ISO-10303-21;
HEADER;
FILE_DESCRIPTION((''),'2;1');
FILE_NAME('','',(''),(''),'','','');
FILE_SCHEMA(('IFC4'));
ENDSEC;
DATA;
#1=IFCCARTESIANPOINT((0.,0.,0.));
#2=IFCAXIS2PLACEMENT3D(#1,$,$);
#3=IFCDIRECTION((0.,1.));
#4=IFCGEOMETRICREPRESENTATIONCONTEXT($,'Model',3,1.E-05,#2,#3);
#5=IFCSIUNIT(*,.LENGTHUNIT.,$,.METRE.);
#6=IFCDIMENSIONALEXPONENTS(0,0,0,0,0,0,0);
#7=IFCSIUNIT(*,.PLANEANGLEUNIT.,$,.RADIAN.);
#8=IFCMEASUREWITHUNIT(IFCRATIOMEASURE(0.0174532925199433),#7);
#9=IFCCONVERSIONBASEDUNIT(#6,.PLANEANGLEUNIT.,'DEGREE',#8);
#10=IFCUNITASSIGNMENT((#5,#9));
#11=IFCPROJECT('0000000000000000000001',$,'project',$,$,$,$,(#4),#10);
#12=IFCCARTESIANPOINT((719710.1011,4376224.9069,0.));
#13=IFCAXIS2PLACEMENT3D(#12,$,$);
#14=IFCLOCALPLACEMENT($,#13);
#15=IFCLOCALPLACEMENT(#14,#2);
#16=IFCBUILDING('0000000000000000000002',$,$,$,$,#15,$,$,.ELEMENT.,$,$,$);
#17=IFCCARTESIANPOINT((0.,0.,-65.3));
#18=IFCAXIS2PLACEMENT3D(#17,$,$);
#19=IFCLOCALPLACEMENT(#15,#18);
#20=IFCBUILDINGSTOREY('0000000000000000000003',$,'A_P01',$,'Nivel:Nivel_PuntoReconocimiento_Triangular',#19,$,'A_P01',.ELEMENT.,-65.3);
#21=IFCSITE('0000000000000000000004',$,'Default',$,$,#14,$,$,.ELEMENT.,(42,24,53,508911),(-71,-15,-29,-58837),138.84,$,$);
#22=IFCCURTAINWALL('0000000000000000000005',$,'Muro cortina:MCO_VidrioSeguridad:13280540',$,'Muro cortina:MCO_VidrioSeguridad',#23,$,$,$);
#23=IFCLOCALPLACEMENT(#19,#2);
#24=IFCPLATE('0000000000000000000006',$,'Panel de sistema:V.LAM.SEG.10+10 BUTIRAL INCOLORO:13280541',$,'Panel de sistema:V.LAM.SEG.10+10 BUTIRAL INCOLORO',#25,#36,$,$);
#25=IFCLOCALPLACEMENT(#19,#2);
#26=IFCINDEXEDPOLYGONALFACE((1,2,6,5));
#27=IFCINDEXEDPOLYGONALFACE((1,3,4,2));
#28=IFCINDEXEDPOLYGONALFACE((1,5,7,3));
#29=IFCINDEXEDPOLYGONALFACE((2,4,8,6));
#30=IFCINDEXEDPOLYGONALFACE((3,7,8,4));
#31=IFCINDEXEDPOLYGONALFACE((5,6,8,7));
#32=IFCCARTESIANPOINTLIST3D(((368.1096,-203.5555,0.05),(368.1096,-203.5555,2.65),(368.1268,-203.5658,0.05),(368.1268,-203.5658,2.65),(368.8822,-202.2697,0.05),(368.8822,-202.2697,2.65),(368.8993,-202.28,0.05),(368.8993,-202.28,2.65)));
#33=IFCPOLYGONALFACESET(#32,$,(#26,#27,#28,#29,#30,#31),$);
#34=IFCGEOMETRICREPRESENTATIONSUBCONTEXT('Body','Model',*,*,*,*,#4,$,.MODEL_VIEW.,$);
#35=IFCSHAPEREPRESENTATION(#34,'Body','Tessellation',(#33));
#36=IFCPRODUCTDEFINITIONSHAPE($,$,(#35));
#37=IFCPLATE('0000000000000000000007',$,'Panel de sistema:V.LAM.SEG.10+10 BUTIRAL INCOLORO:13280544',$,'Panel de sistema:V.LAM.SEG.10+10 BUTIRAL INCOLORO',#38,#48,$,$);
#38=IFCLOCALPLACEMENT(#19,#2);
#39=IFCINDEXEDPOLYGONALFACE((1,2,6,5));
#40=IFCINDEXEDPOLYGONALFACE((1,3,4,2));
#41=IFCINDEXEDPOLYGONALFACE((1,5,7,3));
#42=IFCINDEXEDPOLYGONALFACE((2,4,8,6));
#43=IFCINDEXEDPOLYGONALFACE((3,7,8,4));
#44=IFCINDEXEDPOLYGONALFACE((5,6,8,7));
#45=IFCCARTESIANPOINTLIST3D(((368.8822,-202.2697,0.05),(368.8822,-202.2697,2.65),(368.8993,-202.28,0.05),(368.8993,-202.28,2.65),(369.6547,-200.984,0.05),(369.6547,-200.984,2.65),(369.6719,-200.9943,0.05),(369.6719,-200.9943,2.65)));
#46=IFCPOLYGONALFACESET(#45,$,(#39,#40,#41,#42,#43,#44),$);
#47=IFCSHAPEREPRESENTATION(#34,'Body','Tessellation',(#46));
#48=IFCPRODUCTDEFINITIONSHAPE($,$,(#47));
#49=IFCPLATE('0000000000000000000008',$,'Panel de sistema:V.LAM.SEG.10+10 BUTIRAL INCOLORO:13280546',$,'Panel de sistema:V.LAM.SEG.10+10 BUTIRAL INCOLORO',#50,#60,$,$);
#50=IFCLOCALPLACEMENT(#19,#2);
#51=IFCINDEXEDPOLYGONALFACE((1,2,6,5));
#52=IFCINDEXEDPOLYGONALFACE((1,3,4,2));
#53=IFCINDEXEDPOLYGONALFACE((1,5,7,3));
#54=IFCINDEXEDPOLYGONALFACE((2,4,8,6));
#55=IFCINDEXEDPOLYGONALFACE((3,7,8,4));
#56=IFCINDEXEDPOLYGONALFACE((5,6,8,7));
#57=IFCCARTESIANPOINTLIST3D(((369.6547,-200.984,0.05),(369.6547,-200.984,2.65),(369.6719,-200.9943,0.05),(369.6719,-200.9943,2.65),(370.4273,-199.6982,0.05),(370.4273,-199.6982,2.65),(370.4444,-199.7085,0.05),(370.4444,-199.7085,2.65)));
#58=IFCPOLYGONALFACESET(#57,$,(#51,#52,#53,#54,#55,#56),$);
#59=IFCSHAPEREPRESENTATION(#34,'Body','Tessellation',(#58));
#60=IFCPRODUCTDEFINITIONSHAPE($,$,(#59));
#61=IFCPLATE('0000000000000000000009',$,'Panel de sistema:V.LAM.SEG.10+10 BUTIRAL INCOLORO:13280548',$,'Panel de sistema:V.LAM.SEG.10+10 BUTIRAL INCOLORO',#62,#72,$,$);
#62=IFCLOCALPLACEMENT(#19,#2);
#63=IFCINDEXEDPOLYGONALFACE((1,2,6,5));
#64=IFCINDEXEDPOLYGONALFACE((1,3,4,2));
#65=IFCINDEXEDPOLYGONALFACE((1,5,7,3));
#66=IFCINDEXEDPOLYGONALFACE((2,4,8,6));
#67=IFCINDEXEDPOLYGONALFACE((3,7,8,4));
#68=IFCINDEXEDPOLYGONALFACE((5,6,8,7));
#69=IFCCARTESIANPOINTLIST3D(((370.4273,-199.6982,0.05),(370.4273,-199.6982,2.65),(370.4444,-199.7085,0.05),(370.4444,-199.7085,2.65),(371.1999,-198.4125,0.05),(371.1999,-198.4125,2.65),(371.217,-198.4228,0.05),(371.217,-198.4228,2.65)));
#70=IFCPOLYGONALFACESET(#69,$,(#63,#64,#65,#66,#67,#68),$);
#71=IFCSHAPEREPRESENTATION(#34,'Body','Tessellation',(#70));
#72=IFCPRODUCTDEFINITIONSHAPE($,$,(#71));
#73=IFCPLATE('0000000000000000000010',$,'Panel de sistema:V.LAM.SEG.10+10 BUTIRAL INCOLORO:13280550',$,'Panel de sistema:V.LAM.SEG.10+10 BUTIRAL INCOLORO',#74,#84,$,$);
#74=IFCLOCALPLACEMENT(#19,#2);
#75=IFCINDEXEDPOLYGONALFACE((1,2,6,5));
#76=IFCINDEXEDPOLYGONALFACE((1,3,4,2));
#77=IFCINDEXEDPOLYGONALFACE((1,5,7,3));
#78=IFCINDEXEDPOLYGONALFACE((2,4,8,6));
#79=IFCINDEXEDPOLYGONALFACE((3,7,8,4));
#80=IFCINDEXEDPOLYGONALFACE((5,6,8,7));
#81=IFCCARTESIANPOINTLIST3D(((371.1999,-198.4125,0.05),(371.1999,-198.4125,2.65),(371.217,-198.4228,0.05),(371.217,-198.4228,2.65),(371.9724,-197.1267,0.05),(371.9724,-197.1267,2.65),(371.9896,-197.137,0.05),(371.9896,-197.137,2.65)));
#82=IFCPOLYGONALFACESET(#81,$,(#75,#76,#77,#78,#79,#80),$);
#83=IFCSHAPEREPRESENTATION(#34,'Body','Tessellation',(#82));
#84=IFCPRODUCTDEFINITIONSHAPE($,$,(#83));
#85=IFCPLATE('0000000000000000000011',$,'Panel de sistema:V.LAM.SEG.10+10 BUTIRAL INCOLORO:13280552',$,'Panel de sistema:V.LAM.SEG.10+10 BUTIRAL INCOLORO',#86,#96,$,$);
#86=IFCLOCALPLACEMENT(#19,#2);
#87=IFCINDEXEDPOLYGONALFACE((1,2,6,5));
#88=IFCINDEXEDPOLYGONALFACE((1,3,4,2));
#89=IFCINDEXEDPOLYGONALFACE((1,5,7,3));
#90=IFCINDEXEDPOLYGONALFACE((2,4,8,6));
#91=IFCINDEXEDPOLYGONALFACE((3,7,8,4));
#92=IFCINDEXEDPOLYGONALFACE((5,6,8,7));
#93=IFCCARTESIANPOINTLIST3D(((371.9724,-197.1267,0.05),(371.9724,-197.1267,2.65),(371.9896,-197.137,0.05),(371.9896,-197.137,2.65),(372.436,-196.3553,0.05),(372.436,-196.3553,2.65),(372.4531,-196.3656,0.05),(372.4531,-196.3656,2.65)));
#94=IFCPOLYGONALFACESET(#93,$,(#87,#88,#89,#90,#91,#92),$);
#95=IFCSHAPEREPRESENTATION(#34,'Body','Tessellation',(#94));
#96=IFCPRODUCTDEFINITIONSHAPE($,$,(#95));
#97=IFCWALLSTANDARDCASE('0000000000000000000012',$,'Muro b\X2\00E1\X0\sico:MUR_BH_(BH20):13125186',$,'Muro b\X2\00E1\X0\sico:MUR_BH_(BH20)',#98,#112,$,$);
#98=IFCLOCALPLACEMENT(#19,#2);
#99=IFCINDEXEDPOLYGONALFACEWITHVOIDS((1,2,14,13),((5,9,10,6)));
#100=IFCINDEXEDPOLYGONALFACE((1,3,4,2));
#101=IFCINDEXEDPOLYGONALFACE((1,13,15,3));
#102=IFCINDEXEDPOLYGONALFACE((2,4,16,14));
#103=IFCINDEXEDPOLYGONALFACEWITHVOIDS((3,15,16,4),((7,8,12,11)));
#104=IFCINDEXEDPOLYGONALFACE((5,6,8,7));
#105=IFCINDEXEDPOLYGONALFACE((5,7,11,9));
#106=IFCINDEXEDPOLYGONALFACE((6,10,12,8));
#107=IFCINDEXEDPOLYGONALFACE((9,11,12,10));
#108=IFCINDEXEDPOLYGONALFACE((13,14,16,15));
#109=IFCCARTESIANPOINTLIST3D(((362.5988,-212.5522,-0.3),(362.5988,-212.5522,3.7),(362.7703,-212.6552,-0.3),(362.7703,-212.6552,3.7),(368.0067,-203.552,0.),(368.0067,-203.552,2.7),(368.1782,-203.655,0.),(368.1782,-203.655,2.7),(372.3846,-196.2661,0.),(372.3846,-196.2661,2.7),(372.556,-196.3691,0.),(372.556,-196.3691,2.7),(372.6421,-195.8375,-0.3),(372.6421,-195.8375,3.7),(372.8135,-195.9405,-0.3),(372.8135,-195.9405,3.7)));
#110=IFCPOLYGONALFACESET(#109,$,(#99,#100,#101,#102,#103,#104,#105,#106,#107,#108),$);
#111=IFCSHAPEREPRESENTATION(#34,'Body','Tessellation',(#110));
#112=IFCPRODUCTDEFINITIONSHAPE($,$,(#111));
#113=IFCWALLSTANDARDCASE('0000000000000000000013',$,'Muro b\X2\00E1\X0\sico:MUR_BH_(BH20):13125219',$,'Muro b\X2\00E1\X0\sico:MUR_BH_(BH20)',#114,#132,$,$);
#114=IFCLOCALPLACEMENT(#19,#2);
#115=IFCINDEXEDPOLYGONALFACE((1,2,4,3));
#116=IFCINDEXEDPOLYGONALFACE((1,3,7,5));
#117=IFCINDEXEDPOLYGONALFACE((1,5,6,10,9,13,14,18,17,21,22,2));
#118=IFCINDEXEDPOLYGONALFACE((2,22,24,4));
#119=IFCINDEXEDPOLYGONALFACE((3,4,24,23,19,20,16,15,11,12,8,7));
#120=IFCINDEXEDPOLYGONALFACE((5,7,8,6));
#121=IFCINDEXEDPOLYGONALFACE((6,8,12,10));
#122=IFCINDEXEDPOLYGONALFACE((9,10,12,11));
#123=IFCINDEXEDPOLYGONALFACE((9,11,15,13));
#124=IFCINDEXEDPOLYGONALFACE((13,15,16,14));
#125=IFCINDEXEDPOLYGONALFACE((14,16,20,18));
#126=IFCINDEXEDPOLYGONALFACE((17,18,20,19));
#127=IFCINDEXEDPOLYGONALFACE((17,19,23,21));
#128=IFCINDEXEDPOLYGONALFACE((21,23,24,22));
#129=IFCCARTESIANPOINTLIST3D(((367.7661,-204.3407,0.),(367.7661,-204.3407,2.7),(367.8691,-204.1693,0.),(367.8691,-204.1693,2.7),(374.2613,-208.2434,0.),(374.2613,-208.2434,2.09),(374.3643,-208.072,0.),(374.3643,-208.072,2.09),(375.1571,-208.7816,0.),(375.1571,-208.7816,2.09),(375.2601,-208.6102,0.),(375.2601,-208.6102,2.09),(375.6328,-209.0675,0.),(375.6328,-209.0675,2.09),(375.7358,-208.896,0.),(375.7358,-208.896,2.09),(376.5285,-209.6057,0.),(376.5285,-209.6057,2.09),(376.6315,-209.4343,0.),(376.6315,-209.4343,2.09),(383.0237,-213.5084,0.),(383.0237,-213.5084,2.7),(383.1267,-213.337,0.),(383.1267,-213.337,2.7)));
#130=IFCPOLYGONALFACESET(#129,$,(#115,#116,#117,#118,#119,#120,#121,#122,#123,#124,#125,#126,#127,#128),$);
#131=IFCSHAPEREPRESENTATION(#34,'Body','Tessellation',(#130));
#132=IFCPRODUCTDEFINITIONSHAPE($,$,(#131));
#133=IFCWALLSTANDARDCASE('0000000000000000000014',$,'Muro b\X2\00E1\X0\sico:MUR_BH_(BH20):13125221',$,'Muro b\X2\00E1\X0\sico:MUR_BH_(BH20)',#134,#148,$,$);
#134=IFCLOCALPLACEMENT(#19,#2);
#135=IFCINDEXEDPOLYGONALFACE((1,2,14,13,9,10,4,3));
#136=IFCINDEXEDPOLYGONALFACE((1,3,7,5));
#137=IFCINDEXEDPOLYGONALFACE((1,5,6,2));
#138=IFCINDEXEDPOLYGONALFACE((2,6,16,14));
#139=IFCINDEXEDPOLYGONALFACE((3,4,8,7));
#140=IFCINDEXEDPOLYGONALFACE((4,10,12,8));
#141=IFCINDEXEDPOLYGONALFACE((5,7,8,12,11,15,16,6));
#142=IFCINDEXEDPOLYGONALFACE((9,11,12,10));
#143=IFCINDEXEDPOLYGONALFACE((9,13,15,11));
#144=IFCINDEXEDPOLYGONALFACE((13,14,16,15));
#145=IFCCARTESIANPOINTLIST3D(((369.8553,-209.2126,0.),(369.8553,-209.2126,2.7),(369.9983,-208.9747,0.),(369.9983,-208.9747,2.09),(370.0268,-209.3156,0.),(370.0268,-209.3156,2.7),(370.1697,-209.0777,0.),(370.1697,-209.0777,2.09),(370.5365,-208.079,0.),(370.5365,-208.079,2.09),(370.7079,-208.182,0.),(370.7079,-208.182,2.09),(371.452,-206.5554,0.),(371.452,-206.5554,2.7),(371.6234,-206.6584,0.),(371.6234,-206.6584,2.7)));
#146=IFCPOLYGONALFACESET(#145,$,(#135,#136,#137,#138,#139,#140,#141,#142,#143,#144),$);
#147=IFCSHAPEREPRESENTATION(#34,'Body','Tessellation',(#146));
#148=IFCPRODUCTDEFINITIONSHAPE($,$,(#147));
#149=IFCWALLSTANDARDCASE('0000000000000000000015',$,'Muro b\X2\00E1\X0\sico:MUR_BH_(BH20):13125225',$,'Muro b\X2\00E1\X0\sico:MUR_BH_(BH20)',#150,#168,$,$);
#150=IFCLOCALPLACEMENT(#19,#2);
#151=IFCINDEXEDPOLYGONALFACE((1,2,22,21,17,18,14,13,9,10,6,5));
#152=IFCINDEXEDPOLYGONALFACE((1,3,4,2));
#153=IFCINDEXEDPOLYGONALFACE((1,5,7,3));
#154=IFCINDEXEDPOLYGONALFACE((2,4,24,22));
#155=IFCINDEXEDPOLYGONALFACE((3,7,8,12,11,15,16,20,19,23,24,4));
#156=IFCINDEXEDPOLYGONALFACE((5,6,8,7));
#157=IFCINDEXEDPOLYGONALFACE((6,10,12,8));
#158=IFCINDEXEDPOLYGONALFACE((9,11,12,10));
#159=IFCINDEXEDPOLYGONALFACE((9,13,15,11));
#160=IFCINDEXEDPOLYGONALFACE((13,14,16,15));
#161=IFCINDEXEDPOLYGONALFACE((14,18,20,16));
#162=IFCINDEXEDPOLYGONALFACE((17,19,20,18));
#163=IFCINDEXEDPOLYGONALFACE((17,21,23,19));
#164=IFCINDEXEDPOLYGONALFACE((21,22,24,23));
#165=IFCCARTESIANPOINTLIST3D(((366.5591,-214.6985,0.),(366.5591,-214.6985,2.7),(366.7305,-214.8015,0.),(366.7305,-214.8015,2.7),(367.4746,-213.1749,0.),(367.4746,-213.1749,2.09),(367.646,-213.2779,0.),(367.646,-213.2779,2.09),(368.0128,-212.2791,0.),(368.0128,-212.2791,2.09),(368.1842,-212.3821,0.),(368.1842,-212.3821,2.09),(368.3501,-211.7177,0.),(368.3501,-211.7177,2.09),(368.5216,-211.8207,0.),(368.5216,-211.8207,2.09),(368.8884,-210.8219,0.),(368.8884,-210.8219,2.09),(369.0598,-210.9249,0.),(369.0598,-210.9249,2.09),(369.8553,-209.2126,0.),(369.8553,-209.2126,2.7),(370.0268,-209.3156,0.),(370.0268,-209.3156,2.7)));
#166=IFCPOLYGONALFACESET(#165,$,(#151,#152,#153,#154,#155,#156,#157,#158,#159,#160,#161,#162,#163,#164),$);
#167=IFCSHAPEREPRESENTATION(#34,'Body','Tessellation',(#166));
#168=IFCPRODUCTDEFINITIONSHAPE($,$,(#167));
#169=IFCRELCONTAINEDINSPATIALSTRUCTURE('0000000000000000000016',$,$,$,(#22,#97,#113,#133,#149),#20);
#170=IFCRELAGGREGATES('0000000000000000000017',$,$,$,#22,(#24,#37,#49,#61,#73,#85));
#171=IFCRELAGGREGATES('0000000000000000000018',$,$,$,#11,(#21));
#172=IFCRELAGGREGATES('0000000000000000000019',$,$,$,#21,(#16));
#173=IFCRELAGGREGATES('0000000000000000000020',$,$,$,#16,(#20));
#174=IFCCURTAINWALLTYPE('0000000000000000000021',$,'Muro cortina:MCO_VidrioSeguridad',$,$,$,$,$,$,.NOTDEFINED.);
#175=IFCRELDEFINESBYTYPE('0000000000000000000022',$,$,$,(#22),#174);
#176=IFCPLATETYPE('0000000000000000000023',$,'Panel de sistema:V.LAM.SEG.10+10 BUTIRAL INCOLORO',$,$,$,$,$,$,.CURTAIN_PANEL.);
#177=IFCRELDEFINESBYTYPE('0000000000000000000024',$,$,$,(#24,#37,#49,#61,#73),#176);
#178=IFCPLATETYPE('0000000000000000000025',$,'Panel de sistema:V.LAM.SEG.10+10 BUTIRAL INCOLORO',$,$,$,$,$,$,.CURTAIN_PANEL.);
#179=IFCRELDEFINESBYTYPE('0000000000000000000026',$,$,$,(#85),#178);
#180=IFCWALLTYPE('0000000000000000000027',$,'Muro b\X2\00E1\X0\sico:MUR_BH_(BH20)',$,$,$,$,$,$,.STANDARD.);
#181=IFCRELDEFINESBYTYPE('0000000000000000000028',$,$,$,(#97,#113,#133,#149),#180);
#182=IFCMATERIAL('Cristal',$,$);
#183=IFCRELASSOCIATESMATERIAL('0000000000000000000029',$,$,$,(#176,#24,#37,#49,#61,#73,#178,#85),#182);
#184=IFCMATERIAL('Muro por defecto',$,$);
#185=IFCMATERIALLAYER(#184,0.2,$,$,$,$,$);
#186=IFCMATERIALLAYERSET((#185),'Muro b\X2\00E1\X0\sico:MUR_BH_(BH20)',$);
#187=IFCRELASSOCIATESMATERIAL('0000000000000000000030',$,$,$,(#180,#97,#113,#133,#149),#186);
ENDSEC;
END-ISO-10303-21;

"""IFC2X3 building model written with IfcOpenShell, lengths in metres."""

from ifc_helpers import new_model, entity, si_unit, converted_unit, direction, frame, frame_2d, origin, origin_2d_with_axis, place, context, subcontext, project, spatial, rectangle, extrude, source, transform, mapped, material, layer, layer_set, layer_usage, type_object, type_shapes, element, aggregate, save


model = new_model("IFC2X3")

# Units and contexts
model_context = context("Model", 3, precision=1e-05, world=origin(), true_north=direction((0.0, 1.0)))
body_context = subcontext(model_context, "Body", "Model", "MODEL_VIEW")
ifc_project = project(units=[si_unit("LENGTHUNIT", "METRE"), converted_unit("PLANEANGLEUNIT", "DEGREE", entity("IfcRatioMeasure", 0.0174532925199433), si_unit("PLANEANGLEUNIT", "RADIAN"), dimensions=[0, 0, 0, 0, 0, 0, 0])], contexts=[model_context])

# Site, building, storey
site_placement = place(None, frame((719710.1011, 4376224.9069, 0.0)))
site = spatial("IfcSite", under=ifc_project, at=site_placement, Name="Default", CompositionType="ELEMENT", RefLatitude=(42, 24, 53, 508911), RefLongitude=(-71, -15, -29, -58837), RefElevation=138.84)
building_placement = place(site_placement, origin())
building = spatial("IfcBuilding", under=site, at=building_placement, CompositionType="ELEMENT")
storey_placement = place(building_placement, frame((0.0, 0.0, -65.3)))
storey = spatial("IfcBuildingStorey", under=building, at=storey_placement, Name="A_P01", ObjectType="Nivel:Nivel_PuntoReconocimiento_Triangular", LongName="A_P01", CompositionType="ELEMENT", Elevation=-65.3)

# Curtain wall, plates
curtain_wall_type = type_object("IfcCurtainWallType", Name="Muro cortina:MCO_VidrioSeguridad", PredefinedType="NOTDEFINED")
curtain_wall_placement = place(storey_placement, frame((0.0, 0.0, 65.3)))
curtain_wall = element("IfcCurtainWall", 1, at=curtain_wall_placement, inside=storey, type_object=curtain_wall_type, Name="Muro cortina:MCO_VidrioSeguridad:13280540", ObjectType="Muro cortina:MCO_VidrioSeguridad")
ifc_material_1 = material(Name="Cristal")
plate_type_1 = type_object("IfcPlateType", Name="Panel de sistema:V.LAM.SEG.10+10 BUTIRAL INCOLORO", PredefinedType="CURTAIN_PANEL", material=ifc_material_1)
shared_shape_1 = source(origin(), body_context, "Body", "SweptSolid", [
    extrude(rectangle(XDim=0.02, YDim=1.5, at=origin_2d_with_axis()), frame((0.0, 0.0, 0.0), z_axis=(0.0, 0.0, 1.0), x_axis=(0.0, 1.0, 0.0)), (0.0, 0.0, 1.0), 2.6),
])
type_shapes(plate_type_1, [shared_shape_1])
plate_1_placement = place(curtain_wall_placement, frame((368.5045, -202.9177, -65.25), z_axis=(0.0, 0.0, 1.0), x_axis=(0.515038, 0.857167, 0.0)))
plate_1 = element("IfcPlate", 2, at=plate_1_placement, type_object=plate_type_1, material=ifc_material_1, Name="Panel de sistema:V.LAM.SEG.10+10 BUTIRAL INCOLORO:13280541", ObjectType="Panel de sistema:V.LAM.SEG.10+10 BUTIRAL INCOLORO", context=body_context, shape_type="MappedRepresentation", body=[
    mapped(shared_shape_1, transform((0.0, 0.0, 0.0), scale=1.0)),
])
plate_2_placement = place(curtain_wall_placement, frame((369.277, -201.632, -65.25), z_axis=(0.0, 0.0, 1.0), x_axis=(0.515038, 0.857167, 0.0)))
plate_2 = element("IfcPlate", 3, at=plate_2_placement, type_object=plate_type_1, material=ifc_material_1, Name="Panel de sistema:V.LAM.SEG.10+10 BUTIRAL INCOLORO:13280544", ObjectType="Panel de sistema:V.LAM.SEG.10+10 BUTIRAL INCOLORO", context=body_context, shape_type="MappedRepresentation", body=[
    mapped(shared_shape_1, transform((0.0, 0.0, 0.0), scale=1.0)),
])
plate_3_placement = place(curtain_wall_placement, frame((370.0496, -200.3462, -65.25), z_axis=(0.0, 0.0, 1.0), x_axis=(0.515038, 0.857167, 0.0)))
plate_3 = element("IfcPlate", 4, at=plate_3_placement, type_object=plate_type_1, material=ifc_material_1, Name="Panel de sistema:V.LAM.SEG.10+10 BUTIRAL INCOLORO:13280546", ObjectType="Panel de sistema:V.LAM.SEG.10+10 BUTIRAL INCOLORO", context=body_context, shape_type="MappedRepresentation", body=[
    mapped(shared_shape_1, transform((0.0, 0.0, 0.0), scale=1.0)),
])
plate_4_placement = place(curtain_wall_placement, frame((370.8222, -199.0605, -65.25), z_axis=(0.0, 0.0, 1.0), x_axis=(0.515038, 0.857167, 0.0)))
plate_4 = element("IfcPlate", 5, at=plate_4_placement, type_object=plate_type_1, material=ifc_material_1, Name="Panel de sistema:V.LAM.SEG.10+10 BUTIRAL INCOLORO:13280548", ObjectType="Panel de sistema:V.LAM.SEG.10+10 BUTIRAL INCOLORO", context=body_context, shape_type="MappedRepresentation", body=[
    mapped(shared_shape_1, transform((0.0, 0.0, 0.0), scale=1.0)),
])
plate_5_placement = place(curtain_wall_placement, frame((371.5947, -197.7747, -65.25), z_axis=(0.0, 0.0, 1.0), x_axis=(0.515038, 0.857167, 0.0)))
plate_5 = element("IfcPlate", 6, at=plate_5_placement, type_object=plate_type_1, material=ifc_material_1, Name="Panel de sistema:V.LAM.SEG.10+10 BUTIRAL INCOLORO:13280550", ObjectType="Panel de sistema:V.LAM.SEG.10+10 BUTIRAL INCOLORO", context=body_context, shape_type="MappedRepresentation", body=[
    mapped(shared_shape_1, transform((0.0, 0.0, 0.0), scale=1.0)),
])
plate_type_2 = type_object("IfcPlateType", Name="Panel de sistema:V.LAM.SEG.10+10 BUTIRAL INCOLORO", PredefinedType="CURTAIN_PANEL", material=ifc_material_1)
shared_shape_2 = source(origin(), body_context, "Body", "SweptSolid", [
    extrude(rectangle(XDim=0.02, YDim=0.9, at=origin_2d_with_axis()), frame((0.0, 0.0, 0.0), z_axis=(0.0, 0.0, 1.0), x_axis=(0.0, 1.0, 0.0)), (0.0, 0.0, 1.0), 2.6),
])
type_shapes(plate_type_2, [shared_shape_2])
plate_6_placement = place(curtain_wall_placement, frame((372.2128, -196.7461, -65.25), z_axis=(0.0, 0.0, 1.0), x_axis=(0.515038, 0.857167, 0.0)))
plate_6 = element("IfcPlate", 7, at=plate_6_placement, type_object=plate_type_2, material=ifc_material_1, Name="Panel de sistema:V.LAM.SEG.10+10 BUTIRAL INCOLORO:13280552", ObjectType="Panel de sistema:V.LAM.SEG.10+10 BUTIRAL INCOLORO", context=body_context, shape_type="MappedRepresentation", body=[
    mapped(shared_shape_2, transform((0.0, 0.0, 0.0), scale=1.0)),
])
aggregate(curtain_wall, [plate_1, plate_2, plate_3, plate_4, plate_5, plate_6])

# Wall, opening
ifc_material_2 = material(Name="Muro por defecto")
ifc_layer = layer(ifc_material_2, 0.2)
ifc_layer_set = layer_set([ifc_layer], Name="Muro básico:MUR_BH_(BH20)")
ifc_layer_usage_1 = layer_usage(ifc_layer_set, "AXIS2", "NEGATIVE", 0.1)
wall_type = type_object("IfcWallType", Name="Muro básico:MUR_BH_(BH20)", PredefinedType="STANDARD", material=ifc_layer_set)
wall_1_placement = place(storey_placement, frame((362.6846, -212.6037, -0.3), z_axis=(0.0, 0.0, 1.0), x_axis=(0.515038, 0.857167, 0.0)))
wall_1 = element("IfcWallStandardCase", 8, at=wall_1_placement, inside=storey, type_object=wall_type, material=ifc_layer_usage_1, Name="Muro básico:MUR_BH_(BH20):13125186", ObjectType="Muro básico:MUR_BH_(BH20)", context=body_context, shape_type="SweptSolid", body=[
    extrude(rectangle(XDim=19.5, YDim=0.2, at=frame_2d((9.75, 0.0), x_axis=(-1.0, 0.0))), origin(), (0.0, 0.0, 1.0), 4.0),
])
opening_1_placement = place(wall_1_placement, origin())
element("IfcOpeningElement", 9, at=opening_1_placement, cuts=wall_1, ObjectType="Opening", context=body_context, shape_type="SweptSolid", body=[
    extrude(rectangle(XDim=2.7, YDim=8.5, at=frame_2d((0.0, 0.0), x_axis=(1.0, 0.0))), frame((14.75, -0.2524, 1.65), z_axis=(0.0, 1.0, 0.0), x_axis=(0.0, 0.0, 1.0)), (0.0, 0.0, 1.0), 0.5048),
])

# Wall, openings
ifc_layer_usage_2 = layer_usage(ifc_layer_set, "AXIS2", "NEGATIVE", 0.1)
wall_2_placement = place(storey_placement, frame((367.8176, -204.255, 0.0), z_axis=(0.0, 0.0, 1.0), x_axis=(0.857167, -0.515038, 0.0)))
wall_2 = element("IfcWallStandardCase", 10, at=wall_2_placement, inside=storey, type_object=wall_type, material=ifc_layer_usage_2, Name="Muro básico:MUR_BH_(BH20):13125219", ObjectType="Muro básico:MUR_BH_(BH20)", context=body_context, shape_type="SweptSolid", body=[
    extrude(rectangle(XDim=17.8, YDim=0.2, at=frame_2d((8.9, 0.0), x_axis=(-1.0, 0.0))), origin(), (0.0, 0.0, 1.0), 2.7),
])
opening_2_placement = place(wall_2_placement, frame((-420.4804, -14.3594, 0.0), z_axis=(0.0, 0.0, 1.0), x_axis=(0.857167, 0.515038, 0.0)))
element("IfcOpeningElement", 11, at=opening_2_placement, cuts=wall_2, ObjectType="Opening", context=body_context, shape_type="SweptSolid", body=[
    extrude(rectangle(XDim=2.09, YDim=1.045, at=frame_2d((0.0, 0.0), x_axis=(1.0, 0.0))), frame((374.7092, -208.5125, 1.045), z_axis=(0.515038, 0.857167, 0.0), x_axis=(0.0, 0.0, -1.0)), (0.0, 0.0, 1.0), 0.2),
])
opening_3_placement = place(wall_2_placement, frame((-420.4804, -14.3594, 0.0), z_axis=(0.0, 0.0, 1.0), x_axis=(0.857167, 0.515038, 0.0)))
element("IfcOpeningElement", 12, at=opening_3_placement, cuts=wall_2, ObjectType="Opening", context=body_context, shape_type="SweptSolid", body=[
    extrude(rectangle(XDim=2.09, YDim=1.045, at=frame_2d((0.0, 0.0), x_axis=(0.0, 1.0))), frame((376.0807, -209.3366, 1.045), z_axis=(0.515038, 0.857167, 0.0), x_axis=(0.857167, -0.515038, 0.0)), (0.0, 0.0, 1.0), 0.2),
])

# Wall, opening
ifc_layer_usage_3 = layer_usage(ifc_layer_set, "AXIS2", "NEGATIVE", 0.1)
wall_3_placement = place(storey_placement, frame((369.9411, -209.2641, 0.0), z_axis=(0.0, 0.0, 1.0), x_axis=(0.515038, 0.857167, 0.0)))
wall_3 = element("IfcWallStandardCase", 13, at=wall_3_placement, inside=storey, type_object=wall_type, material=ifc_layer_usage_3, Name="Muro básico:MUR_BH_(BH20):13125221", ObjectType="Muro básico:MUR_BH_(BH20)", context=body_context, shape_type="SweptSolid", body=[
    extrude(rectangle(XDim=3.1, YDim=0.2, at=frame_2d((1.55, 0.0), x_axis=(-1.0, 0.0))), origin(), (0.0, 0.0, 1.0), 2.7),
])
opening_4_placement = place(wall_3_placement, frame((-11.1594, 424.8804, 0.0), z_axis=(0.0, 0.0, 1.0), x_axis=(0.515038, -0.857167, 0.0)))
element("IfcOpeningElement", 14, at=opening_4_placement, cuts=wall_3, ObjectType="Opening", context=body_context, shape_type="SweptSolid", body=[
    extrude(rectangle(XDim=2.09, YDim=1.045, at=frame_2d((0.0, 0.0), x_axis=(0.0, 1.0))), frame((370.4388, -208.6299, 1.045), z_axis=(-0.857167, 0.515038, 0.0), x_axis=(0.515038, 0.857167, 0.0)), (0.0, 0.0, 1.0), 0.2),
])

# Wall, openings
ifc_layer_usage_4 = layer_usage(ifc_layer_set, "AXIS2", "NEGATIVE", 0.1)
wall_4_placement = place(storey_placement, frame((366.6448, -214.75, 0.0), z_axis=(0.0, 0.0, 1.0), x_axis=(0.515038, 0.857167, 0.0)))
wall_4 = element("IfcWallStandardCase", 15, at=wall_4_placement, inside=storey, type_object=wall_type, material=ifc_layer_usage_4, Name="Muro básico:MUR_BH_(BH20):13125225", ObjectType="Muro básico:MUR_BH_(BH20)", context=body_context, shape_type="SweptSolid", body=[
    extrude(rectangle(XDim=6.4, YDim=0.2, at=frame_2d((3.2, 0.0), x_axis=(-1.0, 0.0))), origin(), (0.0, 0.0, 1.0), 2.7),
])
opening_5_placement = place(wall_4_placement, frame((-4.7594, 424.8804, 0.0), z_axis=(0.0, 0.0, 1.0), x_axis=(0.515038, -0.857167, 0.0)))
element("IfcOpeningElement", 16, at=opening_5_placement, cuts=wall_4, ObjectType="Opening", context=body_context, shape_type="SweptSolid", body=[
    extrude(rectangle(XDim=2.09, YDim=1.045, at=frame_2d((0.0, 0.0), x_axis=(0.0, 1.0))), frame((368.7907, -211.3728, 1.045), z_axis=(-0.857167, 0.515038, 0.0), x_axis=(0.515038, 0.857167, 0.0)), (0.0, 0.0, 1.0), 0.2),
])
opening_6_placement = place(wall_4_placement, frame((-4.7594, 424.8804, 0.0), z_axis=(0.0, 0.0, 1.0), x_axis=(0.515038, -0.857167, 0.0)))
element("IfcOpeningElement", 17, at=opening_6_placement, cuts=wall_4, ObjectType="Opening", context=body_context, shape_type="SweptSolid", body=[
    extrude(rectangle(XDim=2.09, YDim=1.045, at=frame_2d((0.0, 0.0), x_axis=(1.0, 0.0))), frame((367.9151, -212.83, 1.045), z_axis=(-0.857167, 0.515038, 0.0), x_axis=(0.0, 0.0, -1.0)), (0.0, 0.0, 1.0), 0.2),
])

save(model, "model.ifc")
